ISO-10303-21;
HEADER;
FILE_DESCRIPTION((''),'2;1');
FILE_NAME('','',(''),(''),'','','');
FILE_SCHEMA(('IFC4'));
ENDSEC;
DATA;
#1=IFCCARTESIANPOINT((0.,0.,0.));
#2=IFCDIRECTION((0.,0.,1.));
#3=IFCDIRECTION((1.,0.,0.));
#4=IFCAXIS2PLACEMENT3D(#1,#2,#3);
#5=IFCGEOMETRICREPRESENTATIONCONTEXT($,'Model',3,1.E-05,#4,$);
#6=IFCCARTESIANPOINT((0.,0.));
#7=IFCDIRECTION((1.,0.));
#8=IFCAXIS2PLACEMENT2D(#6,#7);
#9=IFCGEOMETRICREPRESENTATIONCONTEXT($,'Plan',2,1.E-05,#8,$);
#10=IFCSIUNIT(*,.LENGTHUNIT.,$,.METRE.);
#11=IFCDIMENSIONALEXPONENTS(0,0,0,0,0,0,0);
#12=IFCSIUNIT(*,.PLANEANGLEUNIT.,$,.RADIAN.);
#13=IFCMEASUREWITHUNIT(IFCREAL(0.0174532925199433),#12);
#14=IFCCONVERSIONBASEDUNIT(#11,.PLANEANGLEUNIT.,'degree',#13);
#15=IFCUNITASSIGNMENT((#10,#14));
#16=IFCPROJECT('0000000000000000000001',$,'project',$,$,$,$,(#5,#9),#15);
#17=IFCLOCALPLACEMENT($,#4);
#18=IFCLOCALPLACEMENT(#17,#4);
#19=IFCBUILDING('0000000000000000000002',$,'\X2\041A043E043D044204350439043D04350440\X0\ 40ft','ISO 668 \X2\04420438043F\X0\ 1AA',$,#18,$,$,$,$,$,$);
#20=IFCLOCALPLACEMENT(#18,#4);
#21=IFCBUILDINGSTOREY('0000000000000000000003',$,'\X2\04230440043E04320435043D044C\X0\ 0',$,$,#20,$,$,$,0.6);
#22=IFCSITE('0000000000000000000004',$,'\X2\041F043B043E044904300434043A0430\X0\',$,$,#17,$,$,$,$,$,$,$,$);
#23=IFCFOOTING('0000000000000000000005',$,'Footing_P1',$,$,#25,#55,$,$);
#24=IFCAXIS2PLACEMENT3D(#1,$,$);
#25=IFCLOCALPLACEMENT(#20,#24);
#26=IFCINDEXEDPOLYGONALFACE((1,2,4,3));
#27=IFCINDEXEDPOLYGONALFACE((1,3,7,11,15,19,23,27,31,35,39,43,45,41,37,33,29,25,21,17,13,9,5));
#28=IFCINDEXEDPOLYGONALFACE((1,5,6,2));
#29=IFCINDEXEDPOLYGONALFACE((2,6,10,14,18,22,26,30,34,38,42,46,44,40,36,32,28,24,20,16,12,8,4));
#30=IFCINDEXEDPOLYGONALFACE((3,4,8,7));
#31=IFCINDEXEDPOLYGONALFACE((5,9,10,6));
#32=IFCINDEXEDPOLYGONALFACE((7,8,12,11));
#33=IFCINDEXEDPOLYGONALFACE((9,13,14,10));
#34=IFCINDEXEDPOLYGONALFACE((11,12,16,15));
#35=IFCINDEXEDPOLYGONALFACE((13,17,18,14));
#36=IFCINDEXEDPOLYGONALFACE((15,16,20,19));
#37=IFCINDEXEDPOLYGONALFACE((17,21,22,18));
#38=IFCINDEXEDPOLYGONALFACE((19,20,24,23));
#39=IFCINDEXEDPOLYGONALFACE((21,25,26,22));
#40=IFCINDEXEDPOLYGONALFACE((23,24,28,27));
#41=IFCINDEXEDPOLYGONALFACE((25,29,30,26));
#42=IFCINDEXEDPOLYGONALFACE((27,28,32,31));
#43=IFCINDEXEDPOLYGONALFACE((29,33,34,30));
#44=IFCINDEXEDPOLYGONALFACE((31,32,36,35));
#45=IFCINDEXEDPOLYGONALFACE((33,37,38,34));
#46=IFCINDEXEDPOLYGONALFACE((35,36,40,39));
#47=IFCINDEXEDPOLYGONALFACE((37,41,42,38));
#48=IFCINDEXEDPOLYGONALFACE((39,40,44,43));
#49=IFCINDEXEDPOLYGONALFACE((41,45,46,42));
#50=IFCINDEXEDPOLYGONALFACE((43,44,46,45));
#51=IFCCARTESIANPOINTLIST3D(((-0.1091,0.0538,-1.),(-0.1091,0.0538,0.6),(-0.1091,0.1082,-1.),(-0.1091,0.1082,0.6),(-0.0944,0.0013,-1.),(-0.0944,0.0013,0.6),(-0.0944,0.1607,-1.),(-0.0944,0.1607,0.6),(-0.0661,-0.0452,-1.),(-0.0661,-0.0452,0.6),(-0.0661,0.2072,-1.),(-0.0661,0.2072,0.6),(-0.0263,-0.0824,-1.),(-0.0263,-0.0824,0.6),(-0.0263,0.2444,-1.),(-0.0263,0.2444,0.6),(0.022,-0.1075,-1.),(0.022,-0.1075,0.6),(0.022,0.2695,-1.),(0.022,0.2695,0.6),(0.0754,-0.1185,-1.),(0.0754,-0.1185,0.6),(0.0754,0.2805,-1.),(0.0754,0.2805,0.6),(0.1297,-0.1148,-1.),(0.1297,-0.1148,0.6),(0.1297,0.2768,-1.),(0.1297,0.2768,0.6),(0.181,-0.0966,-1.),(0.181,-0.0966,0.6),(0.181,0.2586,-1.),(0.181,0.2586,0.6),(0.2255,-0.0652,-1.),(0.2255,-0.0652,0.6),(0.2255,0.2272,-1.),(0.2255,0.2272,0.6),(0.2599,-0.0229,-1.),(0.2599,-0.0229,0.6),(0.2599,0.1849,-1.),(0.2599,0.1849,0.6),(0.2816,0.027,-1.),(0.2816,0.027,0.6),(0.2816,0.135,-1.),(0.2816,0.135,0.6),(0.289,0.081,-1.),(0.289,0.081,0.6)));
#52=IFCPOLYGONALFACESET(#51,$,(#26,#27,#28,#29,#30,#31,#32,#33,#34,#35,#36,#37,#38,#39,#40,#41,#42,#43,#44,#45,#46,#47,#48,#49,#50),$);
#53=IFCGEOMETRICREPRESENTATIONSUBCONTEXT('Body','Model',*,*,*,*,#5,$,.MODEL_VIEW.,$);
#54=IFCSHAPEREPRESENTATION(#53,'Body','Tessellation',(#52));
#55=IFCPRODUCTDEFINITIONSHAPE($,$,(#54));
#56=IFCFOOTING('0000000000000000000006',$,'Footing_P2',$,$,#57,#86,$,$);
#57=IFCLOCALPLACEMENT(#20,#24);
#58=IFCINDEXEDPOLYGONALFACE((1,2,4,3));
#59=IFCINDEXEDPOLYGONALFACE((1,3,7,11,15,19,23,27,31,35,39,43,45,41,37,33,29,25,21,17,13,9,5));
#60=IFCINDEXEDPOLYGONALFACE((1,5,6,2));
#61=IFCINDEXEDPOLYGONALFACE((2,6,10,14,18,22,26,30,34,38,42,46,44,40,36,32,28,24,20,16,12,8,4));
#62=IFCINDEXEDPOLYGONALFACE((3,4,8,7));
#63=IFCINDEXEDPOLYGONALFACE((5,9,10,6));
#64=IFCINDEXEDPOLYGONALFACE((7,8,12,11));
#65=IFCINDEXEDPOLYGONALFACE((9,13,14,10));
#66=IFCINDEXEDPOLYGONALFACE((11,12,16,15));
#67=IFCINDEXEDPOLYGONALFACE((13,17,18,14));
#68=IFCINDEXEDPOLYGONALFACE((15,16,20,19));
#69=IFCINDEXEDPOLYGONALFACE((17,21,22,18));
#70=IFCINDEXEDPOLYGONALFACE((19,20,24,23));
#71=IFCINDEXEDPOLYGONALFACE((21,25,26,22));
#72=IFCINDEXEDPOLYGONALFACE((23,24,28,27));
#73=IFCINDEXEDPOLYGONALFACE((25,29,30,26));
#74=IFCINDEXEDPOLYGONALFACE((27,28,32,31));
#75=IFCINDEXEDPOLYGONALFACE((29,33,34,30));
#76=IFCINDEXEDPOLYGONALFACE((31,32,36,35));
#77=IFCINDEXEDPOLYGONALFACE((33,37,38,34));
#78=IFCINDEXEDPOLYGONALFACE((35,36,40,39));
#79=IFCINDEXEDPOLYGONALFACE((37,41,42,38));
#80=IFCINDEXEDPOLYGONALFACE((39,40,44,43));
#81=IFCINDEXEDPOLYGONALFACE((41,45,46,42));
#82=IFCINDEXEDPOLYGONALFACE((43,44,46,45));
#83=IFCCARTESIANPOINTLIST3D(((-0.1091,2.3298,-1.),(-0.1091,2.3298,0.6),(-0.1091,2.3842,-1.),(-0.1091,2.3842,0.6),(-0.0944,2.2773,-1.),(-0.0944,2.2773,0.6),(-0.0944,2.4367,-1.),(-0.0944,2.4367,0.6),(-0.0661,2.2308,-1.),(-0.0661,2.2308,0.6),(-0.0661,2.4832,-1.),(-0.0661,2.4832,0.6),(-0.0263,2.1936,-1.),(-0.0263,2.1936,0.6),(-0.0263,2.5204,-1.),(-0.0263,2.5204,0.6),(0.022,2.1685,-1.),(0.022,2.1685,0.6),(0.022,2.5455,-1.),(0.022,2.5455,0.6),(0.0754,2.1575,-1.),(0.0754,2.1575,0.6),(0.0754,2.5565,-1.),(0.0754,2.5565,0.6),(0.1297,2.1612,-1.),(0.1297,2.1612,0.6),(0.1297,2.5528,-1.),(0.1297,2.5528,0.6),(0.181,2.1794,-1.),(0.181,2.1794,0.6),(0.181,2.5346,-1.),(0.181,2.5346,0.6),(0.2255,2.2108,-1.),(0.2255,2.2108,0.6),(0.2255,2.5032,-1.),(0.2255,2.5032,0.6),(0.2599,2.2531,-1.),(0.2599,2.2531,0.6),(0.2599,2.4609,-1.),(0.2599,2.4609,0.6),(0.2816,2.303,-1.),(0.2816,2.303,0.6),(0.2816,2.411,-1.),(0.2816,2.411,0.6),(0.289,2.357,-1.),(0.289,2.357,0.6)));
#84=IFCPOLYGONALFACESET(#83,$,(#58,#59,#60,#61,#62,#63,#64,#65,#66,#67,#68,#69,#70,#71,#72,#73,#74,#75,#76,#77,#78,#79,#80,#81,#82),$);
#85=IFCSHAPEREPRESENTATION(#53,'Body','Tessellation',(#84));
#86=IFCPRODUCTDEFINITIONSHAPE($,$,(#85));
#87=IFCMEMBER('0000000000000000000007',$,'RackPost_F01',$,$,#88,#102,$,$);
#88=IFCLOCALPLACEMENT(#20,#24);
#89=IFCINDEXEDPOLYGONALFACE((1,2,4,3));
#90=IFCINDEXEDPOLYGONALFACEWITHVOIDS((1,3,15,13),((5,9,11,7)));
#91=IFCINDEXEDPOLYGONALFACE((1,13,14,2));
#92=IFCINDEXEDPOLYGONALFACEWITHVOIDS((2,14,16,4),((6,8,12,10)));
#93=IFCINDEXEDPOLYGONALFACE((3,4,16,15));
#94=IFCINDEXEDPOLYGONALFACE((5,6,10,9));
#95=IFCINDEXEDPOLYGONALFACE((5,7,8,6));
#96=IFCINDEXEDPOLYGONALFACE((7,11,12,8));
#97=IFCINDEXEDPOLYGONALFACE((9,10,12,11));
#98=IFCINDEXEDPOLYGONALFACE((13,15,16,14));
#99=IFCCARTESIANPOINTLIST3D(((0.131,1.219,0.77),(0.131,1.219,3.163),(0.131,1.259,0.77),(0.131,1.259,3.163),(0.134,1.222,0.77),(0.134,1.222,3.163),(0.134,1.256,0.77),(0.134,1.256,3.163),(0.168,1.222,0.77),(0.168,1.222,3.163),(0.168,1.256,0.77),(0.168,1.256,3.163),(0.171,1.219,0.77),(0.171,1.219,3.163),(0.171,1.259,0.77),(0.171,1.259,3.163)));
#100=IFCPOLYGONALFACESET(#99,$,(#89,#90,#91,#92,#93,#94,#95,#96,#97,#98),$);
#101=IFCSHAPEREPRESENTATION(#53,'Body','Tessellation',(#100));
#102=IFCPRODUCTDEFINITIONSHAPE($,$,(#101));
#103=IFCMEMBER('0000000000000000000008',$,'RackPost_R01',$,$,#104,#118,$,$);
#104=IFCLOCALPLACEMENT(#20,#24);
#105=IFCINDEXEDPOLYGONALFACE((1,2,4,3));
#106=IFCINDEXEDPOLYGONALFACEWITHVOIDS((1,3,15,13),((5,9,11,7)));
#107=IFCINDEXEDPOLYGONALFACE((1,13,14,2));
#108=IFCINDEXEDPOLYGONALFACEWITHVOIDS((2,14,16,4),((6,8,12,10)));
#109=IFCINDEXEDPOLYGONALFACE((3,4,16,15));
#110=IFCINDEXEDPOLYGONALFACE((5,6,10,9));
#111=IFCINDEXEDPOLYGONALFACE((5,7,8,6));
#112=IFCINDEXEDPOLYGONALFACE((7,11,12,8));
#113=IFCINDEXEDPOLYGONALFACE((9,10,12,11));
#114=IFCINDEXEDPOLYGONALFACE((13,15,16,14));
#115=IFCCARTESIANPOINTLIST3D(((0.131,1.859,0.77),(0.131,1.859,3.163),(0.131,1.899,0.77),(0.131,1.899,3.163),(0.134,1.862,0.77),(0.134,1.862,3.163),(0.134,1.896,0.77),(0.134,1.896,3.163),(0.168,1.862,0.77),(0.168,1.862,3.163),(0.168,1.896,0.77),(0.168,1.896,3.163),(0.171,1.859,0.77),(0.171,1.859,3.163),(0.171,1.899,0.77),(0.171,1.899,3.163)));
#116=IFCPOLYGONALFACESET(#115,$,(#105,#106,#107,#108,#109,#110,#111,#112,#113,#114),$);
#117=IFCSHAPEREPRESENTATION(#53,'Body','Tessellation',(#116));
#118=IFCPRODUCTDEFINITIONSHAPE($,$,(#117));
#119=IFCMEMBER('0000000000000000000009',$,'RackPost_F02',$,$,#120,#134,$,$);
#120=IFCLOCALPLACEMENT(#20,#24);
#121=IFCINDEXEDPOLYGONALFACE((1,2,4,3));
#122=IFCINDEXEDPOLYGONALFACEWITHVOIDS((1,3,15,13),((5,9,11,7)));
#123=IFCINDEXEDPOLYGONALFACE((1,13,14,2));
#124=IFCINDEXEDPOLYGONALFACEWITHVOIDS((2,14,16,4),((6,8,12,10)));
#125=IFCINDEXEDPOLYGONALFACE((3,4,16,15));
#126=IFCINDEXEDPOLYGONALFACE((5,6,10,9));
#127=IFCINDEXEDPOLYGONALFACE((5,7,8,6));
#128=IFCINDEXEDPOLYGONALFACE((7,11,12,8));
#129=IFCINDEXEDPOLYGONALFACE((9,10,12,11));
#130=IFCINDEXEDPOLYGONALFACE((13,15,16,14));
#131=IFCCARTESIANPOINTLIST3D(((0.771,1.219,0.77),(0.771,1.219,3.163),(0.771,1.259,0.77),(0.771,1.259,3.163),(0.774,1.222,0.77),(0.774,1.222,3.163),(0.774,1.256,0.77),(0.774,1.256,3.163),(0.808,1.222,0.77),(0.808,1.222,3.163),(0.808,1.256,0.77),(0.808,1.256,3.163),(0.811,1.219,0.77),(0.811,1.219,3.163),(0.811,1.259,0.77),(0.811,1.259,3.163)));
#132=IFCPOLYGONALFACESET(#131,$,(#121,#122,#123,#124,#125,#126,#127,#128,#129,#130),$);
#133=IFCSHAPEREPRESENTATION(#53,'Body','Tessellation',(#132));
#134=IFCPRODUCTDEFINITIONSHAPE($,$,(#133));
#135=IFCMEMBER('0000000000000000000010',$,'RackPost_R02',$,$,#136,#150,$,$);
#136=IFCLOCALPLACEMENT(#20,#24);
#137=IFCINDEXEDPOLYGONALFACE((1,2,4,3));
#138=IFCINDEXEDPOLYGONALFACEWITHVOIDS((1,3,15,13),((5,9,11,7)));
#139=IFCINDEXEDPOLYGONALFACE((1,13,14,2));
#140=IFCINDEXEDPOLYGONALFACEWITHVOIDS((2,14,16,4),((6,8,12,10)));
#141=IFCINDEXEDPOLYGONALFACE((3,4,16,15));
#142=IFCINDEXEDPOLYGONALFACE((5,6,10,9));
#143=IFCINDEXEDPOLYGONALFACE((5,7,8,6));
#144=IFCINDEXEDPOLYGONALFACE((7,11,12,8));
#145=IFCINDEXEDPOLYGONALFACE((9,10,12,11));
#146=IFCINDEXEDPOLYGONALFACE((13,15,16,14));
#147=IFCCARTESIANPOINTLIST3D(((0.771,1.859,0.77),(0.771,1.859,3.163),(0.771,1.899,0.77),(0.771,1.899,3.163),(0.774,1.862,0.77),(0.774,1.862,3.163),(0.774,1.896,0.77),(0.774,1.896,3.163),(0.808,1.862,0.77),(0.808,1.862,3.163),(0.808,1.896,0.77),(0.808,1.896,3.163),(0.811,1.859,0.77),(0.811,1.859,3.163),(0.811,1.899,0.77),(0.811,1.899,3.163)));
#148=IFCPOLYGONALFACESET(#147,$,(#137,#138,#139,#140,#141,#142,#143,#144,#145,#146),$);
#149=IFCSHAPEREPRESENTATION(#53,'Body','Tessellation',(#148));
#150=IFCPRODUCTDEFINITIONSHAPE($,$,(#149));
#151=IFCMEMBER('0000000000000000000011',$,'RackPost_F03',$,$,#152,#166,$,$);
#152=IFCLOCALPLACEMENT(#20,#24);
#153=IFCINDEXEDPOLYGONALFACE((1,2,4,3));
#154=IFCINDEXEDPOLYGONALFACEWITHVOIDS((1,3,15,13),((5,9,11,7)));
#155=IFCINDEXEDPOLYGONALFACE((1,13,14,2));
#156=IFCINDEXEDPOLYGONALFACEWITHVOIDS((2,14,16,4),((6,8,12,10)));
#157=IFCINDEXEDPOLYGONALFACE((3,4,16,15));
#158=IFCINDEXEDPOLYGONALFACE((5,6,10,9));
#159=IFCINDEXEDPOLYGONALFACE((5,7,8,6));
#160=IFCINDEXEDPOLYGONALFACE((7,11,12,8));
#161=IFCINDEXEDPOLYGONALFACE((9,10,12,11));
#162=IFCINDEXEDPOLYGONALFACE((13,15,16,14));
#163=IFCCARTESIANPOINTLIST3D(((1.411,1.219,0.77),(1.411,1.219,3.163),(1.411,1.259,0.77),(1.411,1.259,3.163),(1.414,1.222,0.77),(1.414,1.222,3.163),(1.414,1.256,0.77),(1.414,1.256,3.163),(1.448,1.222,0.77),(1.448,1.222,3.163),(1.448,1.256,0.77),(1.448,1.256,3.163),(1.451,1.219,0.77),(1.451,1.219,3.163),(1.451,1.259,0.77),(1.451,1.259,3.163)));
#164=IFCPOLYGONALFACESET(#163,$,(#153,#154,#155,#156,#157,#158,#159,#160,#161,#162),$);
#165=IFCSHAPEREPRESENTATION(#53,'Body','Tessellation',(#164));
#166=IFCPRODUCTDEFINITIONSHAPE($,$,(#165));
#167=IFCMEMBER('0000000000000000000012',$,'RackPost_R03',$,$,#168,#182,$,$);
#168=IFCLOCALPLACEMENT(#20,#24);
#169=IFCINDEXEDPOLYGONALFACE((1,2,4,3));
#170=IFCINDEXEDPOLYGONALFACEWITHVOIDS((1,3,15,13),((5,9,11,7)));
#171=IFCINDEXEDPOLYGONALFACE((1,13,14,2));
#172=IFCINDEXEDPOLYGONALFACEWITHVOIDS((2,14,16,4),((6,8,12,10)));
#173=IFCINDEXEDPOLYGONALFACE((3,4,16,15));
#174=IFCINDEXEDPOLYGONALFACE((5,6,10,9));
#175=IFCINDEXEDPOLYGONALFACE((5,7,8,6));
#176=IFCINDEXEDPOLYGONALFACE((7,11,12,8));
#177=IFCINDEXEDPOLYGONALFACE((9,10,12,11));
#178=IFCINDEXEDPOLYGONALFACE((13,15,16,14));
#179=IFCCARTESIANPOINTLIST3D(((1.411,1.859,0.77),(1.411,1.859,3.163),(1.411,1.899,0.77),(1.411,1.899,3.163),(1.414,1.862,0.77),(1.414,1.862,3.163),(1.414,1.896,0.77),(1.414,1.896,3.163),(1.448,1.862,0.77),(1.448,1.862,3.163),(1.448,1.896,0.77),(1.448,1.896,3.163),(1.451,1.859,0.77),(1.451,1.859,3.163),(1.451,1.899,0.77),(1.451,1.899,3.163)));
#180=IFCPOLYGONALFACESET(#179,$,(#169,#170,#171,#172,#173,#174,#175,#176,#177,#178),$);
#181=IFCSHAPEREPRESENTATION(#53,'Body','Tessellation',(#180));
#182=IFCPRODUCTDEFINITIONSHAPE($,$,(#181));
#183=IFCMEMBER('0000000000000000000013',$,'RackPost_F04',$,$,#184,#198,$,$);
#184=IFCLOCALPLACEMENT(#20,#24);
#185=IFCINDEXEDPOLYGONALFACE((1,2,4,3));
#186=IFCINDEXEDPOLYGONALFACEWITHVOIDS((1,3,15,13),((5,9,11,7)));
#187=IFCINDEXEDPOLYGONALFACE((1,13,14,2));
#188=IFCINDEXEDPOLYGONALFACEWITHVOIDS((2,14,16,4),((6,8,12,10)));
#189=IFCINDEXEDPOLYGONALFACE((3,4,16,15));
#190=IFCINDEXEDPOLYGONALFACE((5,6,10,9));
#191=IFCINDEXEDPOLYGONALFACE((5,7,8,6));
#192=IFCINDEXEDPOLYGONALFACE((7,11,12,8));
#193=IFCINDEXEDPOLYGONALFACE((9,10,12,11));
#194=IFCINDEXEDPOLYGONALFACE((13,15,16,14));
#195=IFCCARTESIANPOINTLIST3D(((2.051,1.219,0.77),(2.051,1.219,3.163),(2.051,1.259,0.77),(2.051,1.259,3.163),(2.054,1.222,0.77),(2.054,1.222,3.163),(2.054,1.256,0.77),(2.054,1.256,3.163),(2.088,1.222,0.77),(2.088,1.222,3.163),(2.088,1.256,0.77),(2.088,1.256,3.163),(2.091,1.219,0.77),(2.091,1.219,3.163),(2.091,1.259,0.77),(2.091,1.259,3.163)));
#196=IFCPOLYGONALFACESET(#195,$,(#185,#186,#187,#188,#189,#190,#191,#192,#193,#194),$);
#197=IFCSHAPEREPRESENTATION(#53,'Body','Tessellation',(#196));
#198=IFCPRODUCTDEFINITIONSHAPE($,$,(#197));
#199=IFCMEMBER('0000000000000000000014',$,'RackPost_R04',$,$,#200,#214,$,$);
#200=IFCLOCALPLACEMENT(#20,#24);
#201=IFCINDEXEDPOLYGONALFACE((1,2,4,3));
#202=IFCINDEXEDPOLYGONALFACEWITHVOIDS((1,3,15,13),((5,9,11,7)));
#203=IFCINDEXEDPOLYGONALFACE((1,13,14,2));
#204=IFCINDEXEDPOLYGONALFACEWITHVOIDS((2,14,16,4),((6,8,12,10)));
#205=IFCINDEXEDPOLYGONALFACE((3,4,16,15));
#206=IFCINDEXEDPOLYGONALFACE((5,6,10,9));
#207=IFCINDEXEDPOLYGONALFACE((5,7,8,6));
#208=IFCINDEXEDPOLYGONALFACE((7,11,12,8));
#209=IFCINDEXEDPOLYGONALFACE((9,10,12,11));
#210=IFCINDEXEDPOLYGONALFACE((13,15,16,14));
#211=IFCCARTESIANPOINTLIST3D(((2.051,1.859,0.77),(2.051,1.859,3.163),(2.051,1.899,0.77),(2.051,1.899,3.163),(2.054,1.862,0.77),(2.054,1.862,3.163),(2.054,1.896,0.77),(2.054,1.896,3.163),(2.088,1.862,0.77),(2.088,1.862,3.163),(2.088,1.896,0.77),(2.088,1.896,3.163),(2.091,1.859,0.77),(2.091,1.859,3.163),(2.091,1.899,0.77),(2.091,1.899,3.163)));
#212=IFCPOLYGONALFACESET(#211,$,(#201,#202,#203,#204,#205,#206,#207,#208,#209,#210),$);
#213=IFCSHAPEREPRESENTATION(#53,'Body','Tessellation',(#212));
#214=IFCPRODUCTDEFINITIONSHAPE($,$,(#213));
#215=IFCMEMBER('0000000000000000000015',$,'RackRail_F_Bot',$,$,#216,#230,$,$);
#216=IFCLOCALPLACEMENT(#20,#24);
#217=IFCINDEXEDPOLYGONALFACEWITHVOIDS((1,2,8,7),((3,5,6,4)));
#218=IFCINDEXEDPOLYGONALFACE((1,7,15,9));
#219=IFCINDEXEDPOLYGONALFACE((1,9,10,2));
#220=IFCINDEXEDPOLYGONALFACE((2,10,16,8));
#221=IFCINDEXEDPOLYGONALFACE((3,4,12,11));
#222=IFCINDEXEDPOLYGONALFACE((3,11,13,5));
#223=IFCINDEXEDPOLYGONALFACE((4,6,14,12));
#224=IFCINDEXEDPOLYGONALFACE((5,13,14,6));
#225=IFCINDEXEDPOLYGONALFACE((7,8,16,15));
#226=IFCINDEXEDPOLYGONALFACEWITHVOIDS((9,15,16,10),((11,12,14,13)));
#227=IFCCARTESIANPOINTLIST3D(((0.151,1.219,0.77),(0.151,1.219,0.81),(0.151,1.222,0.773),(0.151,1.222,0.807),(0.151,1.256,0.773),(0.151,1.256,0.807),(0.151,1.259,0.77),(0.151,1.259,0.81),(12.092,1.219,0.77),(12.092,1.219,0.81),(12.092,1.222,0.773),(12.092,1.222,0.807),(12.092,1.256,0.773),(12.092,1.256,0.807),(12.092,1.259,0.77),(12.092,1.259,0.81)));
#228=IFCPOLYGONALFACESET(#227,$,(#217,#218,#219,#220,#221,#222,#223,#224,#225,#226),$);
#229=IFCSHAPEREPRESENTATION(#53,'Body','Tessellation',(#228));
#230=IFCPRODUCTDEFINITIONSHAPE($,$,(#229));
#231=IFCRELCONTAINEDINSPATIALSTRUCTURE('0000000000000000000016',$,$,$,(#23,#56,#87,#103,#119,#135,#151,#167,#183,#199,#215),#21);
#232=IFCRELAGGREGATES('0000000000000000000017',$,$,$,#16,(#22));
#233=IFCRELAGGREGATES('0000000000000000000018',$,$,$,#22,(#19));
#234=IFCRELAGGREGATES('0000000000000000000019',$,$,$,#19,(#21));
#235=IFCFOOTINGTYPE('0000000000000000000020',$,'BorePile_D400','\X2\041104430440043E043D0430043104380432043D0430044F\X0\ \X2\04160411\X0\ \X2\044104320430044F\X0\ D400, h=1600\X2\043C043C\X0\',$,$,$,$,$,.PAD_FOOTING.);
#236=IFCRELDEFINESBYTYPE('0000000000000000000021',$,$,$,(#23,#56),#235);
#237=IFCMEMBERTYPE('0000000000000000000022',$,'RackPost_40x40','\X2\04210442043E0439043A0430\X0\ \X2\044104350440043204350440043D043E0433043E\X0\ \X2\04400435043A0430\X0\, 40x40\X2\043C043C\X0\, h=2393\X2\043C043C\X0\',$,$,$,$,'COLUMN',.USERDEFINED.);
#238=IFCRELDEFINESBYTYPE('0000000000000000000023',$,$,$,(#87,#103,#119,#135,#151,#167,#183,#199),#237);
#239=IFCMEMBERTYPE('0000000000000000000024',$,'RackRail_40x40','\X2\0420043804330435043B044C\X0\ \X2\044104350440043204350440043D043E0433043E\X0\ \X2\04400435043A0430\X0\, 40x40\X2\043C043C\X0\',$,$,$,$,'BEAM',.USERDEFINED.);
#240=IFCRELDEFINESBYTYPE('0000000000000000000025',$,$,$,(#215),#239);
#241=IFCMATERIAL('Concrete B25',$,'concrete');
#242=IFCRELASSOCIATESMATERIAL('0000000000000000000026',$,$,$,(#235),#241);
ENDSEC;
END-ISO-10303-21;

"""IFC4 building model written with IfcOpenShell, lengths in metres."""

from ifc_helpers import new_model, entity, si_unit, converted_unit, frame, origin_with_axes, origin_2d_with_axis, place, context, subcontext, project, spatial, hollow_rectangle, circle, extrude, material, type_object, element, save


model = new_model("IFC4")

# Units and contexts
model_context = context("Model", 3, precision=1e-05, world=origin_with_axes())
plan_context = context("Plan", 2, precision=1e-05, world=origin_2d_with_axis())
body_context = subcontext(model_context, "Body", "Model", "MODEL_VIEW")
ifc_project = project(units=[si_unit("LENGTHUNIT", "METRE"), converted_unit("PLANEANGLEUNIT", "degree", entity("IfcReal", 0.0174532925199433), si_unit("PLANEANGLEUNIT", "RADIAN"), dimensions=[0, 0, 0, 0, 0, 0, 0])], contexts=[model_context, plan_context])

# Site, building, storey
site_placement = place(None, origin_with_axes())
site = spatial("IfcSite", under=ifc_project, at=site_placement, Name="Площадка")
building_placement = place(site_placement, origin_with_axes())
building = spatial("IfcBuilding", under=site, at=building_placement, Name="Контейнер 40ft", Description="ISO 668 тип 1AA")
storey_placement = place(building_placement, origin_with_axes())
storey = spatial("IfcBuildingStorey", under=building, at=storey_placement, Name="Уровень 0", Elevation=0.6)

# Footings
ifc_material = material(Name="Concrete B25", Category="concrete")
footing_type = type_object("IfcFootingType", Name="BorePile_D400", Description="Буронабивная ЖБ свая D400, h=1600мм", PredefinedType="PAD_FOOTING", material=ifc_material)
for number, where, z_axis, x_axis, name in (
    (1, (0.089, 0.081, -1.0), (0.0, 0.0, 1.0), (1.0, 0.0, 0.0), "Footing_P1"),
    (2, (0.089, 2.357, -1.0), (0.0, 0.0, 1.0), (1.0, 0.0, 0.0), "Footing_P2"),
):
    element("IfcFooting", number, at=place(storey_placement, frame(where, z_axis=z_axis, x_axis=x_axis)), inside=storey, type_object=footing_type, Name=name, context=body_context, shape_type="SweptSolid", body=[
        extrude(circle(Radius=0.2), origin_with_axes(), (0.0, 0.0, 1.0), 1.6),
    ])

# Members
member_type_1 = type_object("IfcMemberType", Name="RackPost_40x40", Description="Стойка серверного река, 40x40мм, h=2393мм", ElementType="COLUMN", PredefinedType="USERDEFINED")
for number, where, z_axis, x_axis, name in (
    (3, (0.151, 1.239, 0.77), (0.0, 0.0, 1.0), (1.0, 0.0, 0.0), "RackPost_F01"),
    (4, (0.151, 1.879, 0.77), (0.0, 0.0, 1.0), (1.0, 0.0, 0.0), "RackPost_R01"),
    (5, (0.791, 1.239, 0.77), (0.0, 0.0, 1.0), (1.0, 0.0, 0.0), "RackPost_F02"),
    (6, (0.791, 1.879, 0.77), (0.0, 0.0, 1.0), (1.0, 0.0, 0.0), "RackPost_R02"),
    (7, (1.431, 1.239, 0.77), (0.0, 0.0, 1.0), (1.0, 0.0, 0.0), "RackPost_F03"),
    (8, (1.431, 1.879, 0.77), (0.0, 0.0, 1.0), (1.0, 0.0, 0.0), "RackPost_R03"),
    (9, (2.071, 1.239, 0.77), (0.0, 0.0, 1.0), (1.0, 0.0, 0.0), "RackPost_F04"),
    (10, (2.071, 1.879, 0.77), (0.0, 0.0, 1.0), (1.0, 0.0, 0.0), "RackPost_R04"),
):
    element("IfcMember", number, at=place(storey_placement, frame(where, z_axis=z_axis, x_axis=x_axis)), inside=storey, type_object=member_type_1, Name=name, context=body_context, shape_type="SweptSolid", body=[
        extrude(hollow_rectangle(XDim=0.04, YDim=0.04, WallThickness=0.003), origin_with_axes(), (0.0, 0.0, 1.0), 2.393),
    ])
member_type_2 = type_object("IfcMemberType", Name="RackRail_40x40", Description="Ригель серверного река, 40x40мм", ElementType="BEAM", PredefinedType="USERDEFINED")
for number, where, z_axis, x_axis, name in (
    (11, (0.151, 1.239, 0.79), (1.0, 0.0, 0.0), (0.0, 1.0, 0.0), "RackRail_F_Bot"),
):
    element("IfcMember", number, at=place(storey_placement, frame(where, z_axis=z_axis, x_axis=x_axis)), inside=storey, type_object=member_type_2, Name=name, context=body_context, shape_type="SweptSolid", body=[
        extrude(hollow_rectangle(XDim=0.04, YDim=0.04, WallThickness=0.003), origin_with_axes(), (0.0, 0.0, 1.0), 11.941),
    ])

save(model, "model.ifc")
